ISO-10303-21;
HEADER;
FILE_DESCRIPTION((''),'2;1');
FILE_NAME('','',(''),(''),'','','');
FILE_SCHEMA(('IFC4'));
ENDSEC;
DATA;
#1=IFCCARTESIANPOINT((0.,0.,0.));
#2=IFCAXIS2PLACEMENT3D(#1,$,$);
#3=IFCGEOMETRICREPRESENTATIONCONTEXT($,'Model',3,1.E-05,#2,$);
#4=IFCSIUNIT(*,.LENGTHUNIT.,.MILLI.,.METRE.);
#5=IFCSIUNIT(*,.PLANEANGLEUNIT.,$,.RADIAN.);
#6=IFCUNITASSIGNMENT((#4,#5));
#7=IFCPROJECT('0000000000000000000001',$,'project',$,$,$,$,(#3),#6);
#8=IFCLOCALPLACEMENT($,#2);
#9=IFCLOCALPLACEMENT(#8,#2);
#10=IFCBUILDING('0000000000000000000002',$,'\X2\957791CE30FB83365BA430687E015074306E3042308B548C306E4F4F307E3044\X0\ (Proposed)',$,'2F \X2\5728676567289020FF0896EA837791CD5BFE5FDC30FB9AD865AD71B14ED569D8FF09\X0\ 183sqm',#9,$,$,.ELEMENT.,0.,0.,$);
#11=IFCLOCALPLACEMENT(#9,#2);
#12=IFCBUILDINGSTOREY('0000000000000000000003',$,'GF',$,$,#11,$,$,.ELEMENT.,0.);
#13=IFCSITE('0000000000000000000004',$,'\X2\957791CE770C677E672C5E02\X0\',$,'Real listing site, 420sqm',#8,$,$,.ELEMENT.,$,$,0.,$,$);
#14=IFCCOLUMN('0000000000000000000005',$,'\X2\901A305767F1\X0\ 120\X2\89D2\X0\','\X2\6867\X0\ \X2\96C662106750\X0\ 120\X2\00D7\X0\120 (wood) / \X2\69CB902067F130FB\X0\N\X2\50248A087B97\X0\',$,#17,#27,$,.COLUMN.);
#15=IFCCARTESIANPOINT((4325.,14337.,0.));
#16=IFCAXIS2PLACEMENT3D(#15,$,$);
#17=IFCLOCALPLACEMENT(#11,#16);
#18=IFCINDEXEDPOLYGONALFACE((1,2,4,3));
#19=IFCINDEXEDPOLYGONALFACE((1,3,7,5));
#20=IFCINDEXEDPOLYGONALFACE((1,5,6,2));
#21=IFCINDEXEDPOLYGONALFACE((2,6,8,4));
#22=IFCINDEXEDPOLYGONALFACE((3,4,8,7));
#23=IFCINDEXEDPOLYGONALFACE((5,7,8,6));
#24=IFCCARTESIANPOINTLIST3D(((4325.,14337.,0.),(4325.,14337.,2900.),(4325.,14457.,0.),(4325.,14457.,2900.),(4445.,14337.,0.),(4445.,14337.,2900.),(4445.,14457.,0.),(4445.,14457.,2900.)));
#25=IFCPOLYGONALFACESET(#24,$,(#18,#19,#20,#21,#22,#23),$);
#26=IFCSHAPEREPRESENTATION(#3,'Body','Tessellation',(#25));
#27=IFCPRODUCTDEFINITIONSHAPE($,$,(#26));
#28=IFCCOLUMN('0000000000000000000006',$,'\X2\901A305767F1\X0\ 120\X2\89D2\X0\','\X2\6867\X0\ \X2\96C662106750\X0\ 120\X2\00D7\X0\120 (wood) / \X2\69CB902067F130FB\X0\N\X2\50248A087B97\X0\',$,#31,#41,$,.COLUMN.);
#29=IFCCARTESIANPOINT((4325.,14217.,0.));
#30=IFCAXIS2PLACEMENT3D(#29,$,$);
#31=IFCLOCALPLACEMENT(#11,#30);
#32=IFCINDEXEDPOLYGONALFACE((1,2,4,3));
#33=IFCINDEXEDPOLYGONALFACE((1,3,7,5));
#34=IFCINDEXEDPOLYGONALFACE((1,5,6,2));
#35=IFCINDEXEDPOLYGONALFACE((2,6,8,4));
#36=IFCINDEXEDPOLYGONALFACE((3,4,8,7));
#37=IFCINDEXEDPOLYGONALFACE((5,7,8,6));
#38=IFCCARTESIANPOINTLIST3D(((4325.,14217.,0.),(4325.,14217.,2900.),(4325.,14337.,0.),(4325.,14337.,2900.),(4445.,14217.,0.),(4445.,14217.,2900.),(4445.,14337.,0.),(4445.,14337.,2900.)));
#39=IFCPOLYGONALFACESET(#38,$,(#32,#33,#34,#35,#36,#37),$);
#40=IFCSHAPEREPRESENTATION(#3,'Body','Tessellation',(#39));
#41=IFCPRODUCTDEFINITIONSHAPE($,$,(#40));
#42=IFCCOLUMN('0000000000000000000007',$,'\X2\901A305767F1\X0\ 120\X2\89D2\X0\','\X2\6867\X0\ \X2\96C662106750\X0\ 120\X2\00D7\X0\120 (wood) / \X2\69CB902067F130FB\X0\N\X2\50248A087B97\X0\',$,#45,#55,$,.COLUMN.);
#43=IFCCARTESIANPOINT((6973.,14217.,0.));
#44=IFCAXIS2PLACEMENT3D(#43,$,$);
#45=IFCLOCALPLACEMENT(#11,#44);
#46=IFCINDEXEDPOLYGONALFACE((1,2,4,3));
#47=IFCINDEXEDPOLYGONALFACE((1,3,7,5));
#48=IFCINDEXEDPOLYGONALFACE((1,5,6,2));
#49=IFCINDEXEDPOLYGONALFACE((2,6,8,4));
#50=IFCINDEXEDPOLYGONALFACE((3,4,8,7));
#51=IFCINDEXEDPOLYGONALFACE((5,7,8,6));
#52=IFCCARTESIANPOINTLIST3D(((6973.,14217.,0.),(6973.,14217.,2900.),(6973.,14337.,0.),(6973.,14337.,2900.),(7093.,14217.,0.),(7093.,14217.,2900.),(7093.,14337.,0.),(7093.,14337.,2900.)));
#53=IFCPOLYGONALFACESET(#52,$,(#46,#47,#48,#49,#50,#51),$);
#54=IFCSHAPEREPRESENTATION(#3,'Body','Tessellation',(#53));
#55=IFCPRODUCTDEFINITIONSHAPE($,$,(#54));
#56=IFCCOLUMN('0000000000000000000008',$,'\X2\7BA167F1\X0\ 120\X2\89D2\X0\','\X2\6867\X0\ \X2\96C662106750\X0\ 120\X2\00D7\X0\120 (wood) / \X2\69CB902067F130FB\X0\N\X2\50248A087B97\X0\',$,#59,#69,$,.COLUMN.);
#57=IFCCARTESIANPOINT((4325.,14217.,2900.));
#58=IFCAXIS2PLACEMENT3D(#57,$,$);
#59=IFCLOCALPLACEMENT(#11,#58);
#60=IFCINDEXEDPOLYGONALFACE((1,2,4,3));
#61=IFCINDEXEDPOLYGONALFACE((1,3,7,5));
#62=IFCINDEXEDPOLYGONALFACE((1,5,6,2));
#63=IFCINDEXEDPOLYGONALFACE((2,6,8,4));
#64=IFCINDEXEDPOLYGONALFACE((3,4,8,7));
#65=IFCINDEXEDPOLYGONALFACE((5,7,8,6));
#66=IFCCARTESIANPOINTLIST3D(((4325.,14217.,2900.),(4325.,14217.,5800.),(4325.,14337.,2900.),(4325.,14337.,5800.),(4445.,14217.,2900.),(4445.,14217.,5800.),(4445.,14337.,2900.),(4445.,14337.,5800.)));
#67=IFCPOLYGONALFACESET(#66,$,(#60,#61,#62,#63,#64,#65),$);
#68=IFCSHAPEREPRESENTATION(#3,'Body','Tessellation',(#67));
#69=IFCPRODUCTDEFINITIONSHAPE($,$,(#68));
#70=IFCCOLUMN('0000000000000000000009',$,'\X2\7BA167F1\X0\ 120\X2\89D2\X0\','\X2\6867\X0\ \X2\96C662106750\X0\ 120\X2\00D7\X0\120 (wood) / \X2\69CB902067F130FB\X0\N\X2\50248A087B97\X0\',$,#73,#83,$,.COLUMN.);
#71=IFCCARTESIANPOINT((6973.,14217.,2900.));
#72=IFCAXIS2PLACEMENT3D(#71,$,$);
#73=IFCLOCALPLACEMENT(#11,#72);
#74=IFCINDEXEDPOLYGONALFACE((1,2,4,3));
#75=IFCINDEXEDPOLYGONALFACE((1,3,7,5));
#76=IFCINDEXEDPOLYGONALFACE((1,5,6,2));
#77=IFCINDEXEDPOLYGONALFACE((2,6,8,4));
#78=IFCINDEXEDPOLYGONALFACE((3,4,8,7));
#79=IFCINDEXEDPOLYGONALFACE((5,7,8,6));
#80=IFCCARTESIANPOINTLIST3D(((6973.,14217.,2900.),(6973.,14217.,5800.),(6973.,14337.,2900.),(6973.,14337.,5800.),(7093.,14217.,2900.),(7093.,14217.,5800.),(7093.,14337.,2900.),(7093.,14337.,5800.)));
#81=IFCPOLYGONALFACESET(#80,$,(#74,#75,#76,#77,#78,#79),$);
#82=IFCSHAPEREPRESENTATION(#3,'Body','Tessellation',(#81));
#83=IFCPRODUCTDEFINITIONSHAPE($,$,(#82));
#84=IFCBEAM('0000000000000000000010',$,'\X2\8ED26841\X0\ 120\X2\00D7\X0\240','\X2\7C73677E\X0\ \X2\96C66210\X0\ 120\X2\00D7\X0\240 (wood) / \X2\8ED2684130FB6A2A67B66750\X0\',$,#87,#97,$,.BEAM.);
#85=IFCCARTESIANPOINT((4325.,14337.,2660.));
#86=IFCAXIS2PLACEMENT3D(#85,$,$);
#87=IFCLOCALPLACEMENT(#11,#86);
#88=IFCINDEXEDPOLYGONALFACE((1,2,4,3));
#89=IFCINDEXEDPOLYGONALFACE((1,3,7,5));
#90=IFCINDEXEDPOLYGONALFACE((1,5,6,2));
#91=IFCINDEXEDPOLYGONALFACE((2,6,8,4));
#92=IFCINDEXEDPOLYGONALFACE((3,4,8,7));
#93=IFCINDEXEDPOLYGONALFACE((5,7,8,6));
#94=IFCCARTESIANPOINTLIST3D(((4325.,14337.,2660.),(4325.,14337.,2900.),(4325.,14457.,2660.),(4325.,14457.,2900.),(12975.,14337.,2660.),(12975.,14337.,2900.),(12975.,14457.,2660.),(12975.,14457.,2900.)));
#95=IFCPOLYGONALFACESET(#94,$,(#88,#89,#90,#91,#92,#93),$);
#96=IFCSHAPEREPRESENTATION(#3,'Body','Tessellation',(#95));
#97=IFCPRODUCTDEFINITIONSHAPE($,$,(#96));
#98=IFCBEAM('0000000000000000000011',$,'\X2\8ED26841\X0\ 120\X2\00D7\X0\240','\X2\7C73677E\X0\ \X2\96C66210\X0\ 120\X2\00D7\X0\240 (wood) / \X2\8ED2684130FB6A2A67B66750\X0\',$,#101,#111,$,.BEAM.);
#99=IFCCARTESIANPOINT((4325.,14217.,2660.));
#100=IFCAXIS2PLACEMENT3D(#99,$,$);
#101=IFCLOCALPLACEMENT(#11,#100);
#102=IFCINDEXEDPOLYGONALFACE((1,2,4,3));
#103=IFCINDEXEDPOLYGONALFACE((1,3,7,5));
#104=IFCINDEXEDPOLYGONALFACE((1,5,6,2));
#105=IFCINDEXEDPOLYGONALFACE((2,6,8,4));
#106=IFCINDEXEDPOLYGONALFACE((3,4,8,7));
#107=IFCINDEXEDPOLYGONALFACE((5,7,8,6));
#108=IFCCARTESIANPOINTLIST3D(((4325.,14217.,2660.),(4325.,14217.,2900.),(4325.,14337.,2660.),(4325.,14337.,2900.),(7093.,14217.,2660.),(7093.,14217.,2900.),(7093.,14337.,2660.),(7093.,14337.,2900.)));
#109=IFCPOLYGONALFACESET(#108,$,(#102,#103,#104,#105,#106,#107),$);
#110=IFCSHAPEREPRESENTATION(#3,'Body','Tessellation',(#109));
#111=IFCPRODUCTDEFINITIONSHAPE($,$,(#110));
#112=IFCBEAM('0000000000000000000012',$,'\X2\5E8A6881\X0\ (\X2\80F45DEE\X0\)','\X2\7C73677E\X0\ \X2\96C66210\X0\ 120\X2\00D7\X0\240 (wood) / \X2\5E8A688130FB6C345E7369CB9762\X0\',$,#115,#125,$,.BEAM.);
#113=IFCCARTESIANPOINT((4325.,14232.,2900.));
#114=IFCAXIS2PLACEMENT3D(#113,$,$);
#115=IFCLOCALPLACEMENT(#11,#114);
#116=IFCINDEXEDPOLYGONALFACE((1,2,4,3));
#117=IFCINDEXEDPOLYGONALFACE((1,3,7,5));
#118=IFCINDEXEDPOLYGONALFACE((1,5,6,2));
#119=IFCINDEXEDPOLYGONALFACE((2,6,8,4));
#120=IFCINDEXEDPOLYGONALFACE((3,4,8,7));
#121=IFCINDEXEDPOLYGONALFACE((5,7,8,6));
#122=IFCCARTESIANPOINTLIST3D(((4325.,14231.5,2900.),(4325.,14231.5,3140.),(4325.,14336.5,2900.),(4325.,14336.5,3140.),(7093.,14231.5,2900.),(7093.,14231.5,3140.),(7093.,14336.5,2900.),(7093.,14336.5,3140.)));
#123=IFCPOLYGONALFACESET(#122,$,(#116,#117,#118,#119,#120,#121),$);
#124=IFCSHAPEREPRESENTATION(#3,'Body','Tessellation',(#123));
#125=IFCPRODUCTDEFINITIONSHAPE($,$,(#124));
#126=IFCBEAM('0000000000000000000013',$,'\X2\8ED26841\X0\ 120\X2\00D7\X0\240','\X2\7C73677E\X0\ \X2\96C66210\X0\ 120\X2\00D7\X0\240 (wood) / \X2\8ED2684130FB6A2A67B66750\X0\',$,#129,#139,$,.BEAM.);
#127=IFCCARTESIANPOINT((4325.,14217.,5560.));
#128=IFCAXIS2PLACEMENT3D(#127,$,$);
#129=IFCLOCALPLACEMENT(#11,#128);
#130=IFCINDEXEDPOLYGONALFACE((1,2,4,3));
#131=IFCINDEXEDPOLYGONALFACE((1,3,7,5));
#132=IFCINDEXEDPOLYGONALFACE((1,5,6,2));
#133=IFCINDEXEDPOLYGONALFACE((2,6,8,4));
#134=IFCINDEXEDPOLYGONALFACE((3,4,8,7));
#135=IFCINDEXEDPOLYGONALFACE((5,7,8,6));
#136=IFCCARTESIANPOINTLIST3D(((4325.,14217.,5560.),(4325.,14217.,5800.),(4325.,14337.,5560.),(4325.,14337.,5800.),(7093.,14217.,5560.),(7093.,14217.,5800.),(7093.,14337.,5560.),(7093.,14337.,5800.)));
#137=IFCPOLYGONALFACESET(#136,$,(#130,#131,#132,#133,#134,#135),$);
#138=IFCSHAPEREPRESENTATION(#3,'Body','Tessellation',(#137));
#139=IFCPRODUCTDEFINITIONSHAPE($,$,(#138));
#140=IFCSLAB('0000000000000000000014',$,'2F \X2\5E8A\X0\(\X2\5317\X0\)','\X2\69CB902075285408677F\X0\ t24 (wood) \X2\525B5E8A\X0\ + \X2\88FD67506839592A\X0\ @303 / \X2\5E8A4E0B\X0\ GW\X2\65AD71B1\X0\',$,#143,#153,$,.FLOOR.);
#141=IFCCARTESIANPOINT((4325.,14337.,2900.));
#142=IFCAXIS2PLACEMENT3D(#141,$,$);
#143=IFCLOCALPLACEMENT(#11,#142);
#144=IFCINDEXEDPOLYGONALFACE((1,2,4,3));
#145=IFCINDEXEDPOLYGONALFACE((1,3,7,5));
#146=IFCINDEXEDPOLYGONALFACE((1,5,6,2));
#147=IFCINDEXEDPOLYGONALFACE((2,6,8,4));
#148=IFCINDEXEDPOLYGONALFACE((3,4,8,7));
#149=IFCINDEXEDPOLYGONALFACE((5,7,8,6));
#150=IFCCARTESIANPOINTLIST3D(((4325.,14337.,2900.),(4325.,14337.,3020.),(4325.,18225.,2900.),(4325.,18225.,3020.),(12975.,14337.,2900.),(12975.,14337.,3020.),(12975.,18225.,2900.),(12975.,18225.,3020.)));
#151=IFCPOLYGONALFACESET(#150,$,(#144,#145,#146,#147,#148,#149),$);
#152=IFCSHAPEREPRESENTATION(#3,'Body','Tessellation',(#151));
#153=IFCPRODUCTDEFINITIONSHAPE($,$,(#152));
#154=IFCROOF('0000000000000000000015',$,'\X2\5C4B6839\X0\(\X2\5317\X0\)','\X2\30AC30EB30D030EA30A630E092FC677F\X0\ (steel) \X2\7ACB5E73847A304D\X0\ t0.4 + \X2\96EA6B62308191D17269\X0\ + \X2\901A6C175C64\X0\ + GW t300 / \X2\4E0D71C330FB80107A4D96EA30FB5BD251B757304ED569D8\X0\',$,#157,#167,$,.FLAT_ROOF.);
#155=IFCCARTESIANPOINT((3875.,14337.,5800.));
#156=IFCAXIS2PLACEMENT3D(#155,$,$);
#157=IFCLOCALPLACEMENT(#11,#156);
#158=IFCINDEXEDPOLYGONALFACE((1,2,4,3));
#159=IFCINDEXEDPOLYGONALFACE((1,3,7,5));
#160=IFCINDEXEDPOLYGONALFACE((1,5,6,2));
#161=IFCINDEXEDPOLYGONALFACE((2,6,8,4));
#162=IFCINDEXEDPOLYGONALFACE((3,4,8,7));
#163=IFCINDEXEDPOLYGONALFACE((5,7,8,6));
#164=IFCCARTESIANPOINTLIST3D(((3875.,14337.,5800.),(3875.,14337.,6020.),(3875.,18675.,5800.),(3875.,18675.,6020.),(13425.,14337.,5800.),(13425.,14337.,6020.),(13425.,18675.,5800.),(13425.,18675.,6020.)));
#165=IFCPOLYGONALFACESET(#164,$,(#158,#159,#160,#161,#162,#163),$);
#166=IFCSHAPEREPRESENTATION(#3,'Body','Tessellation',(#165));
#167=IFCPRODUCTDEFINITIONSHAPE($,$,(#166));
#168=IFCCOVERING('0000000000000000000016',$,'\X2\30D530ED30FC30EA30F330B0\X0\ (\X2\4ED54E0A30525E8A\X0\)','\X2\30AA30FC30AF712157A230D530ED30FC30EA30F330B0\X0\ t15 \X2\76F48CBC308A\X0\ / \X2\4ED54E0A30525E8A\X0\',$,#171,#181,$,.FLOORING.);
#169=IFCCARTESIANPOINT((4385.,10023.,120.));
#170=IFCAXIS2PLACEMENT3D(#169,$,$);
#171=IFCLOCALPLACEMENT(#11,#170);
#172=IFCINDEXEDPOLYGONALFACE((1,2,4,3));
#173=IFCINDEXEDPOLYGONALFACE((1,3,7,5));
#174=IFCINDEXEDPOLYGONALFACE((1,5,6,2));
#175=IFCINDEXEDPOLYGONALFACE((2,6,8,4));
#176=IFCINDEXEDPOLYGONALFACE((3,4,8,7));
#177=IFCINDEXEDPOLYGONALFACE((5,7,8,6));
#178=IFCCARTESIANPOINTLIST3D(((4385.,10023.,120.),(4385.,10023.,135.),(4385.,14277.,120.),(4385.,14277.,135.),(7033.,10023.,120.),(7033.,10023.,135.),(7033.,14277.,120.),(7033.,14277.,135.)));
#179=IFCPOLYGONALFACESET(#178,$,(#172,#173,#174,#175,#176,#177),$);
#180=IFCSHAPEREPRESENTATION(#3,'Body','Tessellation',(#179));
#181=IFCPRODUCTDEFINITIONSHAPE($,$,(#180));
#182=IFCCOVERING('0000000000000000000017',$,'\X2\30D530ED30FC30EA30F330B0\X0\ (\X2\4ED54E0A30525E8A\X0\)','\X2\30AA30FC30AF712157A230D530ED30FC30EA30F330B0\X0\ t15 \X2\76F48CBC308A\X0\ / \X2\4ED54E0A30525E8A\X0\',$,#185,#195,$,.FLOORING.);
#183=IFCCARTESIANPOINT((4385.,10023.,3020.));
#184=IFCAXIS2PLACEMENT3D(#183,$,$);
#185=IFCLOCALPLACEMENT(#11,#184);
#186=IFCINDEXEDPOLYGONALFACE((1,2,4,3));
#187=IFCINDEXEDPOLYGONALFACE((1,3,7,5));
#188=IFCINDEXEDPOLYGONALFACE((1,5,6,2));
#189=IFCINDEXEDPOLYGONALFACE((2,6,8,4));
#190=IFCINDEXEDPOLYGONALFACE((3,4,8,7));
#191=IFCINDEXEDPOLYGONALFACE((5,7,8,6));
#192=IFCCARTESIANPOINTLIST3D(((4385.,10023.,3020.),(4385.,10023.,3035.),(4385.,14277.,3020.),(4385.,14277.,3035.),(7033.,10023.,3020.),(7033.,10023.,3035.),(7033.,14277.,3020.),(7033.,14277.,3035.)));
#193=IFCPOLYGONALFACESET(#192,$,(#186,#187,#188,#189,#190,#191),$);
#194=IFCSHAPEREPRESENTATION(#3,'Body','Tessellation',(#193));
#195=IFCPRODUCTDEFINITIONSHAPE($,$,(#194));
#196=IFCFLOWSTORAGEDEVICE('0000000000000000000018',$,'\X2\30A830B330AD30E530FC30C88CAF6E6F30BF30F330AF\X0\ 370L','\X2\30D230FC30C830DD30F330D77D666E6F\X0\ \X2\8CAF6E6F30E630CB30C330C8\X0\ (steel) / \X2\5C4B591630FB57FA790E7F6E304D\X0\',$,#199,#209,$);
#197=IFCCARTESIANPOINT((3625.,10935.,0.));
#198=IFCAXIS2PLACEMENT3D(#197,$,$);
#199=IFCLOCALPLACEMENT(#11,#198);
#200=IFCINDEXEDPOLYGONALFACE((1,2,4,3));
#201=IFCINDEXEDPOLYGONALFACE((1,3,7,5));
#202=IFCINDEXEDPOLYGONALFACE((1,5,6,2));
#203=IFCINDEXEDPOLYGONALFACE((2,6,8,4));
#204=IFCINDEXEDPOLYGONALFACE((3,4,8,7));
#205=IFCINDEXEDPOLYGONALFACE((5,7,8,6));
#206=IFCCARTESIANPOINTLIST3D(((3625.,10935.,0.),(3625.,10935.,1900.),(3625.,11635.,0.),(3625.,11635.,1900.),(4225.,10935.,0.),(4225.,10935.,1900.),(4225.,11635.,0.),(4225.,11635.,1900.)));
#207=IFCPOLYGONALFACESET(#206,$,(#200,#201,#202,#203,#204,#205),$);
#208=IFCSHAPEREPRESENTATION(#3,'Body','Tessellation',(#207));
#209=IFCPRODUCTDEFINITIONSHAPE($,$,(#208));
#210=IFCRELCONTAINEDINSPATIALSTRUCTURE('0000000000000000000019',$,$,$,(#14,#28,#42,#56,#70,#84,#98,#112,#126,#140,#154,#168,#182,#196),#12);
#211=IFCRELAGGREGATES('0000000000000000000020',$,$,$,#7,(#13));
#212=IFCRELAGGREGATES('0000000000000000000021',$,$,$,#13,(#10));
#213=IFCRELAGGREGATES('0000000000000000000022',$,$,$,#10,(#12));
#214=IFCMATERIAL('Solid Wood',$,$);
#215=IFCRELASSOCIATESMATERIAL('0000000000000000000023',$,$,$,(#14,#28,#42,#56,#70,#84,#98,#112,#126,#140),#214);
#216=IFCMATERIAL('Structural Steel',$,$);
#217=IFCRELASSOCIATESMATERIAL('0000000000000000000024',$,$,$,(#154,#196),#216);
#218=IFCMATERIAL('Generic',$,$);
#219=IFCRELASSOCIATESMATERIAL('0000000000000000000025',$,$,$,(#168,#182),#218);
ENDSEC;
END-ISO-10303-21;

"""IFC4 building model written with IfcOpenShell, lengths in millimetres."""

from ifc_helpers import new_model, si_unit, frame, frame_2d, origin, place, context, project, spatial, rectangle, extrude, material, element, save


model = new_model("IFC4")

# Units and contexts
model_context = context("Model", 3, precision=1e-05, world=origin())
ifc_project = project(units=[si_unit("LENGTHUNIT", "METRE", prefix="MILLI"), si_unit("PLANEANGLEUNIT", "RADIAN")], contexts=[model_context])

# Site, building, storey
site_placement = place(None, origin())
site = spatial("IfcSite", under=ifc_project, at=site_placement, Name="長野県松本市", ObjectType="Real listing site, 420sqm", CompositionType="ELEMENT", RefElevation=0.0)
building_placement = place(site_placement, origin())
building = spatial("IfcBuilding", under=site, at=building_placement, Name="長野・茶室と縁側のある和の住まい (Proposed)", ObjectType="2F 在来木造（雪荷重対応・高断熱仕様） 183sqm", CompositionType="ELEMENT", ElevationOfRefHeight=0.0, ElevationOfTerrain=0.0)
storey_placement = place(building_placement, origin())
storey = spatial("IfcBuildingStorey", under=building, at=storey_placement, Name="GF", CompositionType="ELEMENT", Elevation=0.0)

# Columns
ifc_material_1 = material(Name="Solid Wood")
column_1_placement = place(storey_placement, frame((4325.0, 14337.0, 0.0)))
element("IfcColumn", 1, at=column_1_placement, inside=storey, material=ifc_material_1, Name="通し柱 120角", Description="桧 集成材 120×120 (wood) / 構造柱・N値計算", PredefinedType="COLUMN", context=model_context, shape_type="SweptSolid", body=[
    extrude(rectangle(XDim=120.0, YDim=120.0, at=frame_2d((60.0, 60.0))), frame((4325.0, 14337.0, 0.0)), (0.0, 0.0, 1.0), 2900.0),
])
column_2_placement = place(storey_placement, frame((4325.0, 14217.0, 0.0)))
element("IfcColumn", 2, at=column_2_placement, inside=storey, material=ifc_material_1, Name="通し柱 120角", Description="桧 集成材 120×120 (wood) / 構造柱・N値計算", PredefinedType="COLUMN", context=model_context, shape_type="SweptSolid", body=[
    extrude(rectangle(XDim=120.0, YDim=120.0, at=frame_2d((60.0, 60.0))), frame((4325.0, 14217.0, 0.0)), (0.0, 0.0, 1.0), 2900.0),
])
column_3_placement = place(storey_placement, frame((6973.0, 14217.0, 0.0)))
element("IfcColumn", 3, at=column_3_placement, inside=storey, material=ifc_material_1, Name="通し柱 120角", Description="桧 集成材 120×120 (wood) / 構造柱・N値計算", PredefinedType="COLUMN", context=model_context, shape_type="SweptSolid", body=[
    extrude(rectangle(XDim=120.0, YDim=120.0, at=frame_2d((60.0, 60.0))), frame((6973.0, 14217.0, 0.0)), (0.0, 0.0, 1.0), 2900.0),
])
column_4_placement = place(storey_placement, frame((4325.0, 14217.0, 2900.0)))
element("IfcColumn", 4, at=column_4_placement, inside=storey, material=ifc_material_1, Name="管柱 120角", Description="桧 集成材 120×120 (wood) / 構造柱・N値計算", PredefinedType="COLUMN", context=model_context, shape_type="SweptSolid", body=[
    extrude(rectangle(XDim=120.0, YDim=120.0, at=frame_2d((60.0, 60.0))), frame((4325.0, 14217.0, 2900.0)), (0.0, 0.0, 1.0), 2900.0),
])
column_5_placement = place(storey_placement, frame((6973.0, 14217.0, 2900.0)))
element("IfcColumn", 5, at=column_5_placement, inside=storey, material=ifc_material_1, Name="管柱 120角", Description="桧 集成材 120×120 (wood) / 構造柱・N値計算", PredefinedType="COLUMN", context=model_context, shape_type="SweptSolid", body=[
    extrude(rectangle(XDim=120.0, YDim=120.0, at=frame_2d((60.0, 60.0))), frame((6973.0, 14217.0, 2900.0)), (0.0, 0.0, 1.0), 2900.0),
])

# Beams
beam_1_placement = place(storey_placement, frame((4325.0, 14337.0, 2660.0)))
element("IfcBeam", 6, at=beam_1_placement, inside=storey, material=ifc_material_1, Name="軒桁 120×240", Description="米松 集成 120×240 (wood) / 軒桁・横架材", PredefinedType="BEAM", context=model_context, shape_type="SweptSolid", body=[
    extrude(rectangle(XDim=8650.0, YDim=120.0, at=frame_2d((4325.0, 60.0))), frame((4325.0, 14337.0, 2660.0)), (0.0, 0.0, 1.0), 240.0),
])
beam_2_placement = place(storey_placement, frame((4325.0, 14217.0, 2660.0)))
element("IfcBeam", 7, at=beam_2_placement, inside=storey, material=ifc_material_1, Name="軒桁 120×240", Description="米松 集成 120×240 (wood) / 軒桁・横架材", PredefinedType="BEAM", context=model_context, shape_type="SweptSolid", body=[
    extrude(rectangle(XDim=2768.0, YDim=120.0, at=frame_2d((1384.0, 60.0))), frame((4325.0, 14217.0, 2660.0)), (0.0, 0.0, 1.0), 240.0),
])
beam_3_placement = place(storey_placement, frame((4325.0, 14232.0, 2900.0)))
element("IfcBeam", 8, at=beam_3_placement, inside=storey, material=ifc_material_1, Name="床梁 (胴差)", Description="米松 集成 120×240 (wood) / 床梁・水平構面", PredefinedType="BEAM", context=model_context, shape_type="SweptSolid", body=[
    extrude(rectangle(XDim=2768.0, YDim=105.0, at=frame_2d((1384.0, 52.0))), frame((4325.0, 14232.0, 2900.0)), (0.0, 0.0, 1.0), 240.0),
])
beam_4_placement = place(storey_placement, frame((4325.0, 14217.0, 5560.0)))
element("IfcBeam", 9, at=beam_4_placement, inside=storey, material=ifc_material_1, Name="軒桁 120×240", Description="米松 集成 120×240 (wood) / 軒桁・横架材", PredefinedType="BEAM", context=model_context, shape_type="SweptSolid", body=[
    extrude(rectangle(XDim=2768.0, YDim=120.0, at=frame_2d((1384.0, 60.0))), frame((4325.0, 14217.0, 5560.0)), (0.0, 0.0, 1.0), 240.0),
])

# Slab
slab_1_placement = place(storey_placement, frame((4325.0, 14337.0, 2900.0)))
element("IfcSlab", 10, at=slab_1_placement, inside=storey, material=ifc_material_1, Name="2F 床(北)", Description="構造用合板 t24 (wood) 剛床 + 製材根太 @303 / 床下 GW断熱", PredefinedType="FLOOR", context=model_context, shape_type="SweptSolid", body=[
    extrude(rectangle(XDim=8650.0, YDim=3888.0, at=frame_2d((4325.0, 1944.0))), frame((4325.0, 14337.0, 2900.0)), (0.0, 0.0, 1.0), 120.0),
])

# Roof
ifc_material_2 = material(Name="Structural Steel")
for number, where, name in (
    (11, (3875.0, 14337.0, 5800.0), "屋根(北)"),
):
    element("IfcRoof", number, at=place(storey_placement, frame(where)), inside=storey, material=ifc_material_2, Name=name, Description="ガルバリウム鋼板 (steel) 立平葺き t0.4 + 雪止め金物 + 通気層 + GW t300 / 不燃・耐積雪・寒冷地仕様", PredefinedType="FLAT_ROOF", context=model_context, shape_type="SweptSolid", body=[
        extrude(rectangle(XDim=9550.0, YDim=4338.0, at=frame_2d((4775.0, 2169.0))), frame((3875.0, 14337.0, 5800.0)), (0.0, 0.0, 1.0), 220.0),
    ])

# Coverings
ifc_material_3 = material(Name="Generic")
covering_1_placement = place(storey_placement, frame((4385.0, 10023.0, 120.0)))
element("IfcCovering", 12, at=covering_1_placement, inside=storey, material=ifc_material_3, Name="フローリング (仕上げ床)", Description="オーク無垢フローリング t15 直貼り / 仕上げ床", PredefinedType="FLOORING", context=model_context, shape_type="SweptSolid", body=[
    extrude(rectangle(XDim=2648.0, YDim=4254.0, at=frame_2d((1324.0, 2127.0))), frame((4385.0, 10023.0, 120.0)), (0.0, 0.0, 1.0), 15.0),
])
covering_2_placement = place(storey_placement, frame((4385.0, 10023.0, 3020.0)))
element("IfcCovering", 13, at=covering_2_placement, inside=storey, material=ifc_material_3, Name="フローリング (仕上げ床)", Description="オーク無垢フローリング t15 直貼り / 仕上げ床", PredefinedType="FLOORING", context=model_context, shape_type="SweptSolid", body=[
    extrude(rectangle(XDim=2648.0, YDim=4254.0, at=frame_2d((1324.0, 2127.0))), frame((4385.0, 10023.0, 3020.0)), (0.0, 0.0, 1.0), 15.0),
])

# Flow storage device
flow_storage_device_placement = place(storey_placement, frame((3625.0, 10935.0, 0.0)))
element("IfcFlowStorageDevice", 14, at=flow_storage_device_placement, inside=storey, material=ifc_material_2, Name="エコキュート貯湯タンク 370L", Description="ヒートポンプ給湯 貯湯ユニット (steel) / 屋外・基礎置き", context=model_context, shape_type="SweptSolid", body=[
    extrude(rectangle(XDim=600.0, YDim=700.0, at=frame_2d((300.0, 350.0))), frame((3625.0, 10935.0, 0.0)), (0.0, 0.0, 1.0), 1900.0),
])

save(model, "model.ifc")
